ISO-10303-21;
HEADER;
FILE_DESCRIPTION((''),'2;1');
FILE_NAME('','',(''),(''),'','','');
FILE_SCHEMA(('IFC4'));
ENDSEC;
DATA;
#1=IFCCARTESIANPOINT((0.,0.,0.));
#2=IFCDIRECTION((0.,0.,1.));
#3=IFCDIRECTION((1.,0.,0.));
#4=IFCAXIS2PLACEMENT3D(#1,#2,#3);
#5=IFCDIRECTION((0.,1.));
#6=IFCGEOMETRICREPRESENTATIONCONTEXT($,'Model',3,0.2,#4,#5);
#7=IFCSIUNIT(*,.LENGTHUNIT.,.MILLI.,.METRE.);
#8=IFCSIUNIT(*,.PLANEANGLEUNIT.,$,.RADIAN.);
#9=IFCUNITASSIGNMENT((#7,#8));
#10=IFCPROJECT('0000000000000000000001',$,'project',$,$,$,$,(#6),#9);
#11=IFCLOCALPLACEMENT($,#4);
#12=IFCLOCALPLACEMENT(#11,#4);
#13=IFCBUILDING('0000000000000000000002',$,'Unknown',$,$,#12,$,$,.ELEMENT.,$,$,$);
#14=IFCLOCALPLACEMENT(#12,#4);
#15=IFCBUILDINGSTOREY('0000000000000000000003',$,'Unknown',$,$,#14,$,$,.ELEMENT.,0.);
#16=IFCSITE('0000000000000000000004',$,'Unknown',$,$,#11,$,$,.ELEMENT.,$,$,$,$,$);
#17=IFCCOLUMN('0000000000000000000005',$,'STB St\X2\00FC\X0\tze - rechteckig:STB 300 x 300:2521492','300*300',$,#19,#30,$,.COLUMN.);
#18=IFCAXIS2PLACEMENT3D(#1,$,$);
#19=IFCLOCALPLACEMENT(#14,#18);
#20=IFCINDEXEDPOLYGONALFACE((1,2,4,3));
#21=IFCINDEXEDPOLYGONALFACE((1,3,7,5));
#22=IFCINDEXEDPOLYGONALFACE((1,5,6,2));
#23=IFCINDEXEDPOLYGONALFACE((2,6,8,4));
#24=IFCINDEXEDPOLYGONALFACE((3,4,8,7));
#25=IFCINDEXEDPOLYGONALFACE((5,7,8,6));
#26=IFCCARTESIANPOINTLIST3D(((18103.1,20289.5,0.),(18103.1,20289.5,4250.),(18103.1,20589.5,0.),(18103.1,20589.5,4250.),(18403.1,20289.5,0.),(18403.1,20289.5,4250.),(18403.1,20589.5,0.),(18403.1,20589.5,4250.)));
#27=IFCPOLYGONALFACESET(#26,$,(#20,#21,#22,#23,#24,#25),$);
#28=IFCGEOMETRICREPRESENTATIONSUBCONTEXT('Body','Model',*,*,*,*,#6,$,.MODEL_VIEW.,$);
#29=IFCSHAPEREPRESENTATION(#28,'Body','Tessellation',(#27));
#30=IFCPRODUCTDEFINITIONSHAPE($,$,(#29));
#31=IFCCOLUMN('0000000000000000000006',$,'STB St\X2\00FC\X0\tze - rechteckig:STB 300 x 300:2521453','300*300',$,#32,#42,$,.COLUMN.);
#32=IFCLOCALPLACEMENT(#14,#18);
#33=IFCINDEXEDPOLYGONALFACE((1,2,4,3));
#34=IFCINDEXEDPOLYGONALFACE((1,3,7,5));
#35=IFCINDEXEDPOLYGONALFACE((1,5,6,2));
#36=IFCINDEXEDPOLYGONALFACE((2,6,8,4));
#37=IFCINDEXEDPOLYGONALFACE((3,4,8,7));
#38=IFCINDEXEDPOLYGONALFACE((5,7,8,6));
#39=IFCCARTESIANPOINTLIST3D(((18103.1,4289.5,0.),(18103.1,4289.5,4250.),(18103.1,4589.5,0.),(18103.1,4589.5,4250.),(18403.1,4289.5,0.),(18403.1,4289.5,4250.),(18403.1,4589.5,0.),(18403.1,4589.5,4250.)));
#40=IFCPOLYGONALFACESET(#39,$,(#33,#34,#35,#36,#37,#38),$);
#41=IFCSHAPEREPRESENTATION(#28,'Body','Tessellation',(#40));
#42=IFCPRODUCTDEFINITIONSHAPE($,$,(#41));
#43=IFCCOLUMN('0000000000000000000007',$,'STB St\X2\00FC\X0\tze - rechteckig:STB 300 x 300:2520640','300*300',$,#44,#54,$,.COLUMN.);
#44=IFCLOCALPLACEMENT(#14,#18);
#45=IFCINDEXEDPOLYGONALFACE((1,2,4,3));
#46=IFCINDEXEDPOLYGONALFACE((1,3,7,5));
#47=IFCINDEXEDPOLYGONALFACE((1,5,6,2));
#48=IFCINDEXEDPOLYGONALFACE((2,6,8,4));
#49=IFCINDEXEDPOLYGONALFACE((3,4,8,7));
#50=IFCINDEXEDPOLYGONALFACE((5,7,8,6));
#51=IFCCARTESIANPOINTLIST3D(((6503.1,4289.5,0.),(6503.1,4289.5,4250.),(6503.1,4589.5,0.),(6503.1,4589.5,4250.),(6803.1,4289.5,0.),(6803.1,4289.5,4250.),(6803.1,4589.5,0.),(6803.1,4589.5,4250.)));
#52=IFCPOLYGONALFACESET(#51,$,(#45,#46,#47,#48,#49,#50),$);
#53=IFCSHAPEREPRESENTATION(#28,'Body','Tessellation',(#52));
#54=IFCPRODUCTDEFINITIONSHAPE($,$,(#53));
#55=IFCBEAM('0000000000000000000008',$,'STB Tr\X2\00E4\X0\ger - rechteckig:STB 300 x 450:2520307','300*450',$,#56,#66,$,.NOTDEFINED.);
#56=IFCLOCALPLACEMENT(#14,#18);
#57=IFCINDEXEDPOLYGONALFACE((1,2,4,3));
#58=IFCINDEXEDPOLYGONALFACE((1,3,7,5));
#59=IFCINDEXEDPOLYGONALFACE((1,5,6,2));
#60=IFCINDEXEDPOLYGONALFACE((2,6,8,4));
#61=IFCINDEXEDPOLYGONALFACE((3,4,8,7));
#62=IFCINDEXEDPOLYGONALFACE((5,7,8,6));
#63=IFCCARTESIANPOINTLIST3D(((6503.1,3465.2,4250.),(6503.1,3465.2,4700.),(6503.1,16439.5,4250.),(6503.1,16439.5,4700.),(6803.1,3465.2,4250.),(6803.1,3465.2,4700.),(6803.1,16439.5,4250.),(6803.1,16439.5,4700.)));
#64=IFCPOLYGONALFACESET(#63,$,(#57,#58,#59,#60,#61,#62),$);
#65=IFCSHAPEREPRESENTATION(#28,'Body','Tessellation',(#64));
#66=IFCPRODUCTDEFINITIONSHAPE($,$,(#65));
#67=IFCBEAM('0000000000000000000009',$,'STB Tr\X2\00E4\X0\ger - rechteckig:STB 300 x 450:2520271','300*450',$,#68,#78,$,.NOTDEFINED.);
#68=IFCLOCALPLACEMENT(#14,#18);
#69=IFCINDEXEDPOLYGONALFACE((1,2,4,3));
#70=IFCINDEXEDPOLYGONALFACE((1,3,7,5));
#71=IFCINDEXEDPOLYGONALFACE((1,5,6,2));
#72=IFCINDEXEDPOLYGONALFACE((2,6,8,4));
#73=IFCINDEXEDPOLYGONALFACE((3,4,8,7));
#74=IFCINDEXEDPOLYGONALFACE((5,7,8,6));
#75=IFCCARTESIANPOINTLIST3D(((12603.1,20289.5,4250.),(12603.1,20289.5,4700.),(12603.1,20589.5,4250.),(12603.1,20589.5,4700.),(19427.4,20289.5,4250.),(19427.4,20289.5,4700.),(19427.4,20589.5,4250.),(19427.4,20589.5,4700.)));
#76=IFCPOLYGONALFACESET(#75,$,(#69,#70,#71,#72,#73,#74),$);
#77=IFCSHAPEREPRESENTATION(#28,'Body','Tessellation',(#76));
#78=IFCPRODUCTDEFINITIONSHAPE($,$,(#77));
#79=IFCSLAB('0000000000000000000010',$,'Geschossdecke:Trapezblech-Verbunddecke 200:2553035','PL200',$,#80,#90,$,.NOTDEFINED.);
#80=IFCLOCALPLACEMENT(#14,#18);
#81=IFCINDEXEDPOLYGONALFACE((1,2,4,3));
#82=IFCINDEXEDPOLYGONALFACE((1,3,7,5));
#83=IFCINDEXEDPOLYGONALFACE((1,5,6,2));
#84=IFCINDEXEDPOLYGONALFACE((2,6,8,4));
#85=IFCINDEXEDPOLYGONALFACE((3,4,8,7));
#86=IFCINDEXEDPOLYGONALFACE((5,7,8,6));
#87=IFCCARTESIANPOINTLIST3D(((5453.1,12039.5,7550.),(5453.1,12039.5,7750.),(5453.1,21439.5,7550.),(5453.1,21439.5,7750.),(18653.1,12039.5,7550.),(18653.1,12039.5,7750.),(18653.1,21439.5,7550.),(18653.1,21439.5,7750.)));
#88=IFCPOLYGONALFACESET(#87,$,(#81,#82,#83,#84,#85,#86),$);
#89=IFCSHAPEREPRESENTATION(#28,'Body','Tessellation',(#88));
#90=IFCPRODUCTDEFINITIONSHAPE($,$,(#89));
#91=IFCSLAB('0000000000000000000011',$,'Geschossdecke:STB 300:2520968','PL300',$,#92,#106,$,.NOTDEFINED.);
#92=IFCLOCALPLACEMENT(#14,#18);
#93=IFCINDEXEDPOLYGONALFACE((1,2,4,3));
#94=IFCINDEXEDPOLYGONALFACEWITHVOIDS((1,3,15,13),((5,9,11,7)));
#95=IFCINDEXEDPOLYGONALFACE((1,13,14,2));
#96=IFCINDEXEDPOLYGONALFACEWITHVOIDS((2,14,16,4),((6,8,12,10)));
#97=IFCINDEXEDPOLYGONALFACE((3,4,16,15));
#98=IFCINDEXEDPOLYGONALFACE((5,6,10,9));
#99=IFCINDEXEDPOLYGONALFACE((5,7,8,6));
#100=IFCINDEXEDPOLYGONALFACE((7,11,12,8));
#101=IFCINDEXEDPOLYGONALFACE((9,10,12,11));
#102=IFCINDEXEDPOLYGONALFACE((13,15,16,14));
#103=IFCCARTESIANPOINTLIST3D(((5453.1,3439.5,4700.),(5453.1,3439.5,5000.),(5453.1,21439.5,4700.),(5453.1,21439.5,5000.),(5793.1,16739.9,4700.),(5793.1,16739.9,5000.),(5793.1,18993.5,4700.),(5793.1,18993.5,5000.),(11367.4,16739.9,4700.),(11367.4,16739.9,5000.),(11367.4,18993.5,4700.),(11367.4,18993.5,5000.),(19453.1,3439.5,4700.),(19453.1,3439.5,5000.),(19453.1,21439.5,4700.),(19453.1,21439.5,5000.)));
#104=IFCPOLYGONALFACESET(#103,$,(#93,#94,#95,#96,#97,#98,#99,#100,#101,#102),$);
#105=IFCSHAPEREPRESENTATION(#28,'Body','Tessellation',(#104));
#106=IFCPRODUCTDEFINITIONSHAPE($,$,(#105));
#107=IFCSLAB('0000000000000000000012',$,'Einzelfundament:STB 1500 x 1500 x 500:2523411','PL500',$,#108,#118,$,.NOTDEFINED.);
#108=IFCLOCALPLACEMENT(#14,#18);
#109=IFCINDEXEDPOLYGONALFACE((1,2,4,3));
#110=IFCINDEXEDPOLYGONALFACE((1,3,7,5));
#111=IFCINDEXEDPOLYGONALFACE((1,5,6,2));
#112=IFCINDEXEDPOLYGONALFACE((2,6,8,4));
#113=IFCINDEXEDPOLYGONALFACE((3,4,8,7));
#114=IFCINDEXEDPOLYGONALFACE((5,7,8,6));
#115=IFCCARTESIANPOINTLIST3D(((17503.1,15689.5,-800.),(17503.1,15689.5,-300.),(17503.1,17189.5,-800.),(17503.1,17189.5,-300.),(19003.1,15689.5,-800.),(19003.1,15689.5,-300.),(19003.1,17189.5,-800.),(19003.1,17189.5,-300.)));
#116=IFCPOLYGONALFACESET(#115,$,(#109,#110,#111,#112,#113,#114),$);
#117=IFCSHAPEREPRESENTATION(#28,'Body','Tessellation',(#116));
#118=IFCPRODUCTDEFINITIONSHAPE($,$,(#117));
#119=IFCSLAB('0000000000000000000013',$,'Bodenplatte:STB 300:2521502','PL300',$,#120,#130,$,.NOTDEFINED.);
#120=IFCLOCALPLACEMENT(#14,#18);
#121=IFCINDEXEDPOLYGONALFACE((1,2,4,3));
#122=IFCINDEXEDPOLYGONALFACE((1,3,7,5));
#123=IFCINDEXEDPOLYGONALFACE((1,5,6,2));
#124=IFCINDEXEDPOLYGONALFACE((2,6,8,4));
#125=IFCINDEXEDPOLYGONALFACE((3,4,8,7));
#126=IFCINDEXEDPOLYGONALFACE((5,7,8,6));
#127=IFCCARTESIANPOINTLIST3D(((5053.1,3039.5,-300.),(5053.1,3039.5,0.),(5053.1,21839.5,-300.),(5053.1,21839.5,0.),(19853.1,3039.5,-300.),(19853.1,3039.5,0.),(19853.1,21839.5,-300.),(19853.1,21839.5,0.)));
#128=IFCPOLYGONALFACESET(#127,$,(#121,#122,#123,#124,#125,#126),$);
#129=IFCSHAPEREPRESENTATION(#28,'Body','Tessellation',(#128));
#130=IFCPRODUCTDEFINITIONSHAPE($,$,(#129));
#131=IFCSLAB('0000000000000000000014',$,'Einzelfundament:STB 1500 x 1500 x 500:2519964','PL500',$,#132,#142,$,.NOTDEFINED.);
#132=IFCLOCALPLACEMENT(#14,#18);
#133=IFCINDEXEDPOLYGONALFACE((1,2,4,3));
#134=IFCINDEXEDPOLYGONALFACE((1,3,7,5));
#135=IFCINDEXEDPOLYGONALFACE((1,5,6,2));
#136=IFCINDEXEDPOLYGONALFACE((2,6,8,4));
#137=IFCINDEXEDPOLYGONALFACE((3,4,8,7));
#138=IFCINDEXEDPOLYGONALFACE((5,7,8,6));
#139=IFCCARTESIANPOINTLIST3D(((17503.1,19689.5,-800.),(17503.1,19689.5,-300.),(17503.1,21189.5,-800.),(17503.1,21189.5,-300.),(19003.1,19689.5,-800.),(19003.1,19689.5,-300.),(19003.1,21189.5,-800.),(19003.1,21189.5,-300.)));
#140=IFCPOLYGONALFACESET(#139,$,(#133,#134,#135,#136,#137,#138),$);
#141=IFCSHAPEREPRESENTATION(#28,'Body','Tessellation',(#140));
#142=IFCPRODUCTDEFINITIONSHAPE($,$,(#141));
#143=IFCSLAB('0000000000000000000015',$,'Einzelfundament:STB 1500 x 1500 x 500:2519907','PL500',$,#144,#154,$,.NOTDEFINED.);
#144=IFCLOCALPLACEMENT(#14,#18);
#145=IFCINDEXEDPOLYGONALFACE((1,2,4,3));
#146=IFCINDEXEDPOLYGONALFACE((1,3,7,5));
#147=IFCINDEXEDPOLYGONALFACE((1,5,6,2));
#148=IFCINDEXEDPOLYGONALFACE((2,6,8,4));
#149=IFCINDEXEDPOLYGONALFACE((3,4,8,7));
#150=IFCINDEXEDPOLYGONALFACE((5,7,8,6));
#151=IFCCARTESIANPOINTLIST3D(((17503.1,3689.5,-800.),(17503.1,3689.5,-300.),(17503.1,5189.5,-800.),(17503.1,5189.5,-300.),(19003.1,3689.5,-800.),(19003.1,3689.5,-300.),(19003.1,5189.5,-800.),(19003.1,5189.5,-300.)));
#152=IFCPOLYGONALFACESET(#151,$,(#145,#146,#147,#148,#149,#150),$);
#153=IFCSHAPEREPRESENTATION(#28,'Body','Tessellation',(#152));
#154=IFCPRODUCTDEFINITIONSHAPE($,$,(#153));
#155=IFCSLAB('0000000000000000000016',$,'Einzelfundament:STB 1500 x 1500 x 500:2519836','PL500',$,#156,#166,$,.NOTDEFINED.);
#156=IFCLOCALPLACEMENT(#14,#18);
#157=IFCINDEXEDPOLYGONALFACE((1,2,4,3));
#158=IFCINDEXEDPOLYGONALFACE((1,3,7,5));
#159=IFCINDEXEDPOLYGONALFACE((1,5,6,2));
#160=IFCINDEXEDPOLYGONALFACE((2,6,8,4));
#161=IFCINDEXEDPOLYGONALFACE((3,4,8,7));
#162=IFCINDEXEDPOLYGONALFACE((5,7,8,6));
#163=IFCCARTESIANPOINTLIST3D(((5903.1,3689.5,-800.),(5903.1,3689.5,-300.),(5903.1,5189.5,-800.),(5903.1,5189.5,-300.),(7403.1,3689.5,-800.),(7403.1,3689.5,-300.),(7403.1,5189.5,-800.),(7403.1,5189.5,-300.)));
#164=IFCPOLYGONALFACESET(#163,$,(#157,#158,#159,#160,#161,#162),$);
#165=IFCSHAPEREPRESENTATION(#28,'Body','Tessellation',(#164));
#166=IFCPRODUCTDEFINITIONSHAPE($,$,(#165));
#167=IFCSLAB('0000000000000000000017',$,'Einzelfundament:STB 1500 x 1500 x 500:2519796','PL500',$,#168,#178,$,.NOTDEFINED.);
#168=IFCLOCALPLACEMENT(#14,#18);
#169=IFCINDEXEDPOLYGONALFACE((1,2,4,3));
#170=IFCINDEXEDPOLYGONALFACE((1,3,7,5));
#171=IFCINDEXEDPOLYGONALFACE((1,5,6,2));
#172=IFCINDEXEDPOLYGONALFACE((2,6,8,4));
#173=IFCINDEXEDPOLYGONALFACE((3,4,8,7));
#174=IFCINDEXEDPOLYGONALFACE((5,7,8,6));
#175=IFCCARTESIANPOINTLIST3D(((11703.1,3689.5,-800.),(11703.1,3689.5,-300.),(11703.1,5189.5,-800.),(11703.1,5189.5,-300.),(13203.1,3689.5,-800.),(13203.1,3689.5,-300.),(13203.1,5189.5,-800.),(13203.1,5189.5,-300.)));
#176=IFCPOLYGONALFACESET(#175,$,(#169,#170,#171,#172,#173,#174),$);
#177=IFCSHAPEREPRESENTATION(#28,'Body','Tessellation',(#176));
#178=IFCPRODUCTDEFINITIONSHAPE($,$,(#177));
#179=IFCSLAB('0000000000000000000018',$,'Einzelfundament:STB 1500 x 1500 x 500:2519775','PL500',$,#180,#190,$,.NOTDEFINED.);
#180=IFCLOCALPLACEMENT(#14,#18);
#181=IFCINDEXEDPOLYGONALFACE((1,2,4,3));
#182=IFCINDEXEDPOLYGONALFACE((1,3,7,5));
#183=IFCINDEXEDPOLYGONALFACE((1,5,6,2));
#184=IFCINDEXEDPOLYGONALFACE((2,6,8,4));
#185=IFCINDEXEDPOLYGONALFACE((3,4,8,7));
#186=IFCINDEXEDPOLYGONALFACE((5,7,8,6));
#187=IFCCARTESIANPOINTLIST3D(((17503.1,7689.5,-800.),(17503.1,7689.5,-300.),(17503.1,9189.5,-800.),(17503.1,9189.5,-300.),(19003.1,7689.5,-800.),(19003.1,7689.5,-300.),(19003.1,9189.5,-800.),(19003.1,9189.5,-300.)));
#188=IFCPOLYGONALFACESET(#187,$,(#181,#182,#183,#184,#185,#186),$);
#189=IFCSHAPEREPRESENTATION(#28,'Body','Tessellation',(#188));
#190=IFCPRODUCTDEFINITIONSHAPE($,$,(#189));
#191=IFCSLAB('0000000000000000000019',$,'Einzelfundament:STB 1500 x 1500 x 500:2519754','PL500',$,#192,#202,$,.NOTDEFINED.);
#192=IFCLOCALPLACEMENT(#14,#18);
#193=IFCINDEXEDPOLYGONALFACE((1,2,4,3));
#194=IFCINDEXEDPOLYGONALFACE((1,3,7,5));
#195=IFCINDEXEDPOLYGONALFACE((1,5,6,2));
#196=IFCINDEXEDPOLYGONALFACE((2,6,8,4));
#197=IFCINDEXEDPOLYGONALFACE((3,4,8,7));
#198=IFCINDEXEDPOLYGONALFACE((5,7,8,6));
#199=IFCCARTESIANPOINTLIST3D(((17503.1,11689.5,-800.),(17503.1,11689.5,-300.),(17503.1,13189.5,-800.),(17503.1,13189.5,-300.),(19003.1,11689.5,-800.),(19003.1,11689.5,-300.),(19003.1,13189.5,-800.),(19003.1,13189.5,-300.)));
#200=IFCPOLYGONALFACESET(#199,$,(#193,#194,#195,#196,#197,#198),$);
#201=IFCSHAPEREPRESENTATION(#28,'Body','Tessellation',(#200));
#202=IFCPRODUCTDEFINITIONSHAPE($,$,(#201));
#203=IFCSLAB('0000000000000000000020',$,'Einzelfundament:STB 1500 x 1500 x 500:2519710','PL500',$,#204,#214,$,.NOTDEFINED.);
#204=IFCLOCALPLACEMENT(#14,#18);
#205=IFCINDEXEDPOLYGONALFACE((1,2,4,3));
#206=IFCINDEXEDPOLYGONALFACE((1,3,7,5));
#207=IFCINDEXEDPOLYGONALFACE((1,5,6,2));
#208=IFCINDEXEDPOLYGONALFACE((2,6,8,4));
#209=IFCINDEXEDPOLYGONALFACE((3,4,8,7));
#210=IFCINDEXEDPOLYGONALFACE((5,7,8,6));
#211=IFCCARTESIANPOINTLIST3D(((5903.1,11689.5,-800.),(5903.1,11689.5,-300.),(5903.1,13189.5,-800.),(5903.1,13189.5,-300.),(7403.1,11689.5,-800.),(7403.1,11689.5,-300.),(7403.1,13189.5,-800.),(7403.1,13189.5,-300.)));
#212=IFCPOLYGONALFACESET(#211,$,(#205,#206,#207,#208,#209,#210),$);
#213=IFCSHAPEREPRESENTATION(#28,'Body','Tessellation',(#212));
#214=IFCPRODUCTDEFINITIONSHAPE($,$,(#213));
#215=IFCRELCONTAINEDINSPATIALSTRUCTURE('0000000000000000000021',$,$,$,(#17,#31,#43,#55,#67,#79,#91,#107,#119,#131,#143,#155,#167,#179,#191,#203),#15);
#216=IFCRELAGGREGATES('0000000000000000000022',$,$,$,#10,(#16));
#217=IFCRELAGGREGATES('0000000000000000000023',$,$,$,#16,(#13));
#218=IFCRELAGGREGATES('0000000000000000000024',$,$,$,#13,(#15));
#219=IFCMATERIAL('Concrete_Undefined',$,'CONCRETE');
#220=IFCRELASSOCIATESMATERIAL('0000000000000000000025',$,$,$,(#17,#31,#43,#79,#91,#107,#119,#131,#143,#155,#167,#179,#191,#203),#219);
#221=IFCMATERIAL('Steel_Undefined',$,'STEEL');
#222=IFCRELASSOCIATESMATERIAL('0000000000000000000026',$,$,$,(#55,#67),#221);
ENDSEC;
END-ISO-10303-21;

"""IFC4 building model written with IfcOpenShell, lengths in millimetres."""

from ifc_helpers import new_model, si_unit, direction, frame, origin_with_axes, place, context, subcontext, project, spatial, line, indexed_curve, outline, extrude, material, element, save


model = new_model("IFC4")

# Units and contexts
model_context = context("Model", 3, precision=0.2, world=origin_with_axes(), true_north=direction((0.0, 1.0)))
body_context = subcontext(model_context, "Body", "Model", "MODEL_VIEW")
ifc_project = project(units=[si_unit("LENGTHUNIT", "METRE", prefix="MILLI"), si_unit("PLANEANGLEUNIT", "RADIAN")], contexts=[model_context])

# Site, building, storey
site_placement = place(None, origin_with_axes())
site = spatial("IfcSite", under=ifc_project, at=site_placement, Name="Unknown", CompositionType="ELEMENT")
building_placement = place(site_placement, origin_with_axes())
building = spatial("IfcBuilding", under=site, at=building_placement, Name="Unknown", CompositionType="ELEMENT")
storey_placement = place(building_placement, origin_with_axes())
storey = spatial("IfcBuildingStorey", under=building, at=storey_placement, Name="Unknown", CompositionType="ELEMENT", Elevation=0.0)

# Columns
ifc_material_1 = material(Name="Concrete_Undefined", Category="CONCRETE")
for number, where, z_axis, x_axis, name in (
    (1, (18253.1, 20439.5, 0.0), (1.0, 0.0, 0.0), (0.0, 0.0, 1.0), "STB Stütze - rechteckig:STB 300 x 300:2521492"),
    (2, (18253.1, 4439.5, 0.0), (1.0, 0.0, 0.0), (0.0, 0.0, 1.0), "STB Stütze - rechteckig:STB 300 x 300:2521453"),
    (3, (6653.1, 4439.5, 0.0), (1.0, 0.0, 0.0), (0.0, 0.0, 1.0), "STB Stütze - rechteckig:STB 300 x 300:2520640"),
):
    element("IfcColumn", number, at=place(storey_placement, frame(where, z_axis=z_axis, x_axis=x_axis)), inside=storey, material=ifc_material_1, Name=name, Description="300*300", PredefinedType="COLUMN", context=body_context, shape_type="SolidModel", body=[
        extrude(outline(indexed_curve([(-150.0, -150.0), (150.0, -150.0), (150.0, 150.0), (-150.0, 150.0)], segments=[line(1, 2, 3, 4, 1)])), frame((0.0, 0.0, 0.0), z_axis=(-1.0, 0.0, 0.0), x_axis=(0.0, 0.0, 1.0)), (0.0, 0.0, -1.0), 4250.0),
    ])

# Beams
ifc_material_2 = material(Name="Steel_Undefined", Category="STEEL")
beam_1_placement = place(storey_placement, frame((6653.1, 16439.5, 4475.0), z_axis=(0.0, 0.0, 1.0), x_axis=(0.0, -1.0, 0.0)))
element("IfcBeam", 4, at=beam_1_placement, inside=storey, material=ifc_material_2, Name="STB Träger - rechteckig:STB 300 x 450:2520307", Description="300*450", PredefinedType="NOTDEFINED", context=body_context, shape_type="SolidModel", body=[
    extrude(outline(indexed_curve([(-225.0, -150.0), (225.0, -150.0), (225.0, 150.0), (-225.0, 150.0)], segments=[line(1, 2, 3, 4, 1)])), frame((0.0, 0.0, 0.0), z_axis=(-1.0, 0.0, 0.0), x_axis=(0.0, 0.0, 1.0)), (0.0, 0.0, -1.0), 12974.3),
])
beam_2_placement = place(storey_placement, frame((12603.1, 20439.5, 4475.0), z_axis=(0.0, 0.0, 1.0), x_axis=(1.0, 0.0, 0.0)))
element("IfcBeam", 5, at=beam_2_placement, inside=storey, material=ifc_material_2, Name="STB Träger - rechteckig:STB 300 x 450:2520271", Description="300*450", PredefinedType="NOTDEFINED", context=body_context, shape_type="SolidModel", body=[
    extrude(outline(indexed_curve([(-225.0, -150.0), (225.0, -150.0), (225.0, 150.0), (-225.0, 150.0)], segments=[line(1, 2, 3, 4, 1)])), frame((0.0, 0.0, 0.0), z_axis=(-1.0, 0.0, 0.0), x_axis=(0.0, 0.0, 1.0)), (0.0, 0.0, -1.0), 6824.3),
])

# Slab
slab_1_placement = place(storey_placement, frame((5453.1, 21439.5, 7650.0), z_axis=(0.0, 0.0, 1.0), x_axis=(0.0, -1.0, 0.0)))
element("IfcSlab", 6, at=slab_1_placement, inside=storey, material=ifc_material_1, Name="Geschossdecke:Trapezblech-Verbunddecke 200:2553035", Description="PL200", PredefinedType="NOTDEFINED", context=body_context, shape_type="SolidModel", body=[
    extrude(outline(indexed_curve([(0.0, 0.0), (9400.0, 0.0), (9400.0, 13200.0), (0.0, 13200.0)], segments=[line(1, 2, 3, 4, 1)])), frame((0.0, 0.0, 100.0), z_axis=(0.0, 0.0, 1.0), x_axis=(1.0, 0.0, 0.0)), (0.0, 0.0, -1.0), 200.0),
])

# Slab, voiding feature
slab_2_placement = place(storey_placement, frame((19453.1, 3439.5, 4850.0), z_axis=(0.0, 0.0, 1.0), x_axis=(0.0, 1.0, 0.0)))
slab_2 = element("IfcSlab", 7, at=slab_2_placement, inside=storey, material=ifc_material_1, Name="Geschossdecke:STB 300:2520968", Description="PL300", PredefinedType="NOTDEFINED", context=body_context, shape_type="SolidModel", body=[
    extrude(outline(indexed_curve([(0.0, 0.0), (18000.0, 0.0), (18000.0, 14000.0), (0.0, 14000.0)], segments=[line(1, 2, 3, 4, 1)])), frame((0.0, 0.0, 150.0), z_axis=(0.0, 0.0, 1.0), x_axis=(1.0, 0.0, 0.0)), (0.0, 0.0, -1.0), 300.0),
])
voiding_feature_placement = place(slab_2_placement, frame((14427.2, 10872.8, 150.0), z_axis=(-1.0, 0.0, 0.0), x_axis=(0.0, 0.0, -1.0)))
element("IfcVoidingFeature", 8, at=voiding_feature_placement, cuts=slab_2, Name="Geschossdecke:STB 300:712247", PredefinedType="HOLE", context=body_context, shape_type="SolidModel", body=[
    extrude(outline(indexed_curve([(-1126.8, -2787.2), (1126.8, -2787.2), (1126.8, 2787.2), (-1126.8, 2787.2)], segments=[line(1, 2, 3, 4, 1)])), frame((0.0, 0.0, 0.0), z_axis=(-1.0, 0.0, 0.0), x_axis=(0.0, 0.0, 1.0)), (0.0, 0.0, -1.0), 300.0),
])

# Slabs
slab_3_placement = place(storey_placement, frame((17503.1, 17189.5, -550.0), z_axis=(0.0, 0.0, -1.0), x_axis=(1.0, 0.0, 0.0)))
element("IfcSlab", 9, at=slab_3_placement, inside=storey, material=ifc_material_1, Name="Einzelfundament:STB 1500 x 1500 x 500:2523411", Description="PL500", PredefinedType="NOTDEFINED", context=body_context, shape_type="SolidModel", body=[
    extrude(outline(indexed_curve([(0.0, 0.0), (1500.0, 0.0), (1500.0, 1500.0), (0.0, 1500.0)], segments=[line(1, 2, 3, 4, 1)])), frame((0.0, 0.0, 250.0), z_axis=(0.0, 0.0, 1.0), x_axis=(1.0, 0.0, 0.0)), (0.0, 0.0, -1.0), 500.0),
])
slab_4_placement = place(storey_placement, frame((5053.1, 21839.5, -150.0), z_axis=(0.0, 0.0, 1.0), x_axis=(0.0, -1.0, 0.0)))
element("IfcSlab", 10, at=slab_4_placement, inside=storey, material=ifc_material_1, Name="Bodenplatte:STB 300:2521502", Description="PL300", PredefinedType="NOTDEFINED", context=body_context, shape_type="SolidModel", body=[
    extrude(outline(indexed_curve([(0.0, 0.0), (18800.0, 0.0), (18800.0, 14800.0), (0.0, 14800.0)], segments=[line(1, 2, 3, 4, 1)])), frame((0.0, 0.0, 150.0), z_axis=(0.0, 0.0, 1.0), x_axis=(1.0, 0.0, 0.0)), (0.0, 0.0, -1.0), 300.0),
])
for number, where, z_axis, x_axis, name in (
    (11, (17503.1, 21189.5, -550.0), (0.0, 0.0, -1.0), (1.0, 0.0, 0.0), "Einzelfundament:STB 1500 x 1500 x 500:2519964"),
    (12, (17503.1, 5189.5, -550.0), (0.0, 0.0, -1.0), (1.0, 0.0, 0.0), "Einzelfundament:STB 1500 x 1500 x 500:2519907"),
    (13, (5903.1, 5189.5, -550.0), (0.0, 0.0, -1.0), (1.0, 0.0, 0.0), "Einzelfundament:STB 1500 x 1500 x 500:2519836"),
    (14, (13203.1, 5189.5, -550.0), (0.0, 0.0, -1.0), (0.0, -1.0, 0.0), "Einzelfundament:STB 1500 x 1500 x 500:2519796"),
    (15, (17503.1, 9189.5, -550.0), (0.0, 0.0, -1.0), (1.0, 0.0, 0.0), "Einzelfundament:STB 1500 x 1500 x 500:2519775"),
    (16, (17503.1, 13189.5, -550.0), (0.0, 0.0, -1.0), (1.0, 0.0, 0.0), "Einzelfundament:STB 1500 x 1500 x 500:2519754"),
    (17, (5903.1, 13189.5, -550.0), (0.0, 0.0, -1.0), (1.0, 0.0, 0.0), "Einzelfundament:STB 1500 x 1500 x 500:2519710"),
):
    element("IfcSlab", number, at=place(storey_placement, frame(where, z_axis=z_axis, x_axis=x_axis)), inside=storey, material=ifc_material_1, Name=name, Description="PL500", PredefinedType="NOTDEFINED", context=body_context, shape_type="SolidModel", body=[
        extrude(outline(indexed_curve([(0.0, 0.0), (1500.0, 0.0), (1500.0, 1500.0), (0.0, 1500.0)], segments=[line(1, 2, 3, 4, 1)])), frame((0.0, 0.0, 250.0), z_axis=(0.0, 0.0, 1.0), x_axis=(1.0, 0.0, 0.0)), (0.0, 0.0, -1.0), 500.0),
    ])

save(model, "model.ifc")
